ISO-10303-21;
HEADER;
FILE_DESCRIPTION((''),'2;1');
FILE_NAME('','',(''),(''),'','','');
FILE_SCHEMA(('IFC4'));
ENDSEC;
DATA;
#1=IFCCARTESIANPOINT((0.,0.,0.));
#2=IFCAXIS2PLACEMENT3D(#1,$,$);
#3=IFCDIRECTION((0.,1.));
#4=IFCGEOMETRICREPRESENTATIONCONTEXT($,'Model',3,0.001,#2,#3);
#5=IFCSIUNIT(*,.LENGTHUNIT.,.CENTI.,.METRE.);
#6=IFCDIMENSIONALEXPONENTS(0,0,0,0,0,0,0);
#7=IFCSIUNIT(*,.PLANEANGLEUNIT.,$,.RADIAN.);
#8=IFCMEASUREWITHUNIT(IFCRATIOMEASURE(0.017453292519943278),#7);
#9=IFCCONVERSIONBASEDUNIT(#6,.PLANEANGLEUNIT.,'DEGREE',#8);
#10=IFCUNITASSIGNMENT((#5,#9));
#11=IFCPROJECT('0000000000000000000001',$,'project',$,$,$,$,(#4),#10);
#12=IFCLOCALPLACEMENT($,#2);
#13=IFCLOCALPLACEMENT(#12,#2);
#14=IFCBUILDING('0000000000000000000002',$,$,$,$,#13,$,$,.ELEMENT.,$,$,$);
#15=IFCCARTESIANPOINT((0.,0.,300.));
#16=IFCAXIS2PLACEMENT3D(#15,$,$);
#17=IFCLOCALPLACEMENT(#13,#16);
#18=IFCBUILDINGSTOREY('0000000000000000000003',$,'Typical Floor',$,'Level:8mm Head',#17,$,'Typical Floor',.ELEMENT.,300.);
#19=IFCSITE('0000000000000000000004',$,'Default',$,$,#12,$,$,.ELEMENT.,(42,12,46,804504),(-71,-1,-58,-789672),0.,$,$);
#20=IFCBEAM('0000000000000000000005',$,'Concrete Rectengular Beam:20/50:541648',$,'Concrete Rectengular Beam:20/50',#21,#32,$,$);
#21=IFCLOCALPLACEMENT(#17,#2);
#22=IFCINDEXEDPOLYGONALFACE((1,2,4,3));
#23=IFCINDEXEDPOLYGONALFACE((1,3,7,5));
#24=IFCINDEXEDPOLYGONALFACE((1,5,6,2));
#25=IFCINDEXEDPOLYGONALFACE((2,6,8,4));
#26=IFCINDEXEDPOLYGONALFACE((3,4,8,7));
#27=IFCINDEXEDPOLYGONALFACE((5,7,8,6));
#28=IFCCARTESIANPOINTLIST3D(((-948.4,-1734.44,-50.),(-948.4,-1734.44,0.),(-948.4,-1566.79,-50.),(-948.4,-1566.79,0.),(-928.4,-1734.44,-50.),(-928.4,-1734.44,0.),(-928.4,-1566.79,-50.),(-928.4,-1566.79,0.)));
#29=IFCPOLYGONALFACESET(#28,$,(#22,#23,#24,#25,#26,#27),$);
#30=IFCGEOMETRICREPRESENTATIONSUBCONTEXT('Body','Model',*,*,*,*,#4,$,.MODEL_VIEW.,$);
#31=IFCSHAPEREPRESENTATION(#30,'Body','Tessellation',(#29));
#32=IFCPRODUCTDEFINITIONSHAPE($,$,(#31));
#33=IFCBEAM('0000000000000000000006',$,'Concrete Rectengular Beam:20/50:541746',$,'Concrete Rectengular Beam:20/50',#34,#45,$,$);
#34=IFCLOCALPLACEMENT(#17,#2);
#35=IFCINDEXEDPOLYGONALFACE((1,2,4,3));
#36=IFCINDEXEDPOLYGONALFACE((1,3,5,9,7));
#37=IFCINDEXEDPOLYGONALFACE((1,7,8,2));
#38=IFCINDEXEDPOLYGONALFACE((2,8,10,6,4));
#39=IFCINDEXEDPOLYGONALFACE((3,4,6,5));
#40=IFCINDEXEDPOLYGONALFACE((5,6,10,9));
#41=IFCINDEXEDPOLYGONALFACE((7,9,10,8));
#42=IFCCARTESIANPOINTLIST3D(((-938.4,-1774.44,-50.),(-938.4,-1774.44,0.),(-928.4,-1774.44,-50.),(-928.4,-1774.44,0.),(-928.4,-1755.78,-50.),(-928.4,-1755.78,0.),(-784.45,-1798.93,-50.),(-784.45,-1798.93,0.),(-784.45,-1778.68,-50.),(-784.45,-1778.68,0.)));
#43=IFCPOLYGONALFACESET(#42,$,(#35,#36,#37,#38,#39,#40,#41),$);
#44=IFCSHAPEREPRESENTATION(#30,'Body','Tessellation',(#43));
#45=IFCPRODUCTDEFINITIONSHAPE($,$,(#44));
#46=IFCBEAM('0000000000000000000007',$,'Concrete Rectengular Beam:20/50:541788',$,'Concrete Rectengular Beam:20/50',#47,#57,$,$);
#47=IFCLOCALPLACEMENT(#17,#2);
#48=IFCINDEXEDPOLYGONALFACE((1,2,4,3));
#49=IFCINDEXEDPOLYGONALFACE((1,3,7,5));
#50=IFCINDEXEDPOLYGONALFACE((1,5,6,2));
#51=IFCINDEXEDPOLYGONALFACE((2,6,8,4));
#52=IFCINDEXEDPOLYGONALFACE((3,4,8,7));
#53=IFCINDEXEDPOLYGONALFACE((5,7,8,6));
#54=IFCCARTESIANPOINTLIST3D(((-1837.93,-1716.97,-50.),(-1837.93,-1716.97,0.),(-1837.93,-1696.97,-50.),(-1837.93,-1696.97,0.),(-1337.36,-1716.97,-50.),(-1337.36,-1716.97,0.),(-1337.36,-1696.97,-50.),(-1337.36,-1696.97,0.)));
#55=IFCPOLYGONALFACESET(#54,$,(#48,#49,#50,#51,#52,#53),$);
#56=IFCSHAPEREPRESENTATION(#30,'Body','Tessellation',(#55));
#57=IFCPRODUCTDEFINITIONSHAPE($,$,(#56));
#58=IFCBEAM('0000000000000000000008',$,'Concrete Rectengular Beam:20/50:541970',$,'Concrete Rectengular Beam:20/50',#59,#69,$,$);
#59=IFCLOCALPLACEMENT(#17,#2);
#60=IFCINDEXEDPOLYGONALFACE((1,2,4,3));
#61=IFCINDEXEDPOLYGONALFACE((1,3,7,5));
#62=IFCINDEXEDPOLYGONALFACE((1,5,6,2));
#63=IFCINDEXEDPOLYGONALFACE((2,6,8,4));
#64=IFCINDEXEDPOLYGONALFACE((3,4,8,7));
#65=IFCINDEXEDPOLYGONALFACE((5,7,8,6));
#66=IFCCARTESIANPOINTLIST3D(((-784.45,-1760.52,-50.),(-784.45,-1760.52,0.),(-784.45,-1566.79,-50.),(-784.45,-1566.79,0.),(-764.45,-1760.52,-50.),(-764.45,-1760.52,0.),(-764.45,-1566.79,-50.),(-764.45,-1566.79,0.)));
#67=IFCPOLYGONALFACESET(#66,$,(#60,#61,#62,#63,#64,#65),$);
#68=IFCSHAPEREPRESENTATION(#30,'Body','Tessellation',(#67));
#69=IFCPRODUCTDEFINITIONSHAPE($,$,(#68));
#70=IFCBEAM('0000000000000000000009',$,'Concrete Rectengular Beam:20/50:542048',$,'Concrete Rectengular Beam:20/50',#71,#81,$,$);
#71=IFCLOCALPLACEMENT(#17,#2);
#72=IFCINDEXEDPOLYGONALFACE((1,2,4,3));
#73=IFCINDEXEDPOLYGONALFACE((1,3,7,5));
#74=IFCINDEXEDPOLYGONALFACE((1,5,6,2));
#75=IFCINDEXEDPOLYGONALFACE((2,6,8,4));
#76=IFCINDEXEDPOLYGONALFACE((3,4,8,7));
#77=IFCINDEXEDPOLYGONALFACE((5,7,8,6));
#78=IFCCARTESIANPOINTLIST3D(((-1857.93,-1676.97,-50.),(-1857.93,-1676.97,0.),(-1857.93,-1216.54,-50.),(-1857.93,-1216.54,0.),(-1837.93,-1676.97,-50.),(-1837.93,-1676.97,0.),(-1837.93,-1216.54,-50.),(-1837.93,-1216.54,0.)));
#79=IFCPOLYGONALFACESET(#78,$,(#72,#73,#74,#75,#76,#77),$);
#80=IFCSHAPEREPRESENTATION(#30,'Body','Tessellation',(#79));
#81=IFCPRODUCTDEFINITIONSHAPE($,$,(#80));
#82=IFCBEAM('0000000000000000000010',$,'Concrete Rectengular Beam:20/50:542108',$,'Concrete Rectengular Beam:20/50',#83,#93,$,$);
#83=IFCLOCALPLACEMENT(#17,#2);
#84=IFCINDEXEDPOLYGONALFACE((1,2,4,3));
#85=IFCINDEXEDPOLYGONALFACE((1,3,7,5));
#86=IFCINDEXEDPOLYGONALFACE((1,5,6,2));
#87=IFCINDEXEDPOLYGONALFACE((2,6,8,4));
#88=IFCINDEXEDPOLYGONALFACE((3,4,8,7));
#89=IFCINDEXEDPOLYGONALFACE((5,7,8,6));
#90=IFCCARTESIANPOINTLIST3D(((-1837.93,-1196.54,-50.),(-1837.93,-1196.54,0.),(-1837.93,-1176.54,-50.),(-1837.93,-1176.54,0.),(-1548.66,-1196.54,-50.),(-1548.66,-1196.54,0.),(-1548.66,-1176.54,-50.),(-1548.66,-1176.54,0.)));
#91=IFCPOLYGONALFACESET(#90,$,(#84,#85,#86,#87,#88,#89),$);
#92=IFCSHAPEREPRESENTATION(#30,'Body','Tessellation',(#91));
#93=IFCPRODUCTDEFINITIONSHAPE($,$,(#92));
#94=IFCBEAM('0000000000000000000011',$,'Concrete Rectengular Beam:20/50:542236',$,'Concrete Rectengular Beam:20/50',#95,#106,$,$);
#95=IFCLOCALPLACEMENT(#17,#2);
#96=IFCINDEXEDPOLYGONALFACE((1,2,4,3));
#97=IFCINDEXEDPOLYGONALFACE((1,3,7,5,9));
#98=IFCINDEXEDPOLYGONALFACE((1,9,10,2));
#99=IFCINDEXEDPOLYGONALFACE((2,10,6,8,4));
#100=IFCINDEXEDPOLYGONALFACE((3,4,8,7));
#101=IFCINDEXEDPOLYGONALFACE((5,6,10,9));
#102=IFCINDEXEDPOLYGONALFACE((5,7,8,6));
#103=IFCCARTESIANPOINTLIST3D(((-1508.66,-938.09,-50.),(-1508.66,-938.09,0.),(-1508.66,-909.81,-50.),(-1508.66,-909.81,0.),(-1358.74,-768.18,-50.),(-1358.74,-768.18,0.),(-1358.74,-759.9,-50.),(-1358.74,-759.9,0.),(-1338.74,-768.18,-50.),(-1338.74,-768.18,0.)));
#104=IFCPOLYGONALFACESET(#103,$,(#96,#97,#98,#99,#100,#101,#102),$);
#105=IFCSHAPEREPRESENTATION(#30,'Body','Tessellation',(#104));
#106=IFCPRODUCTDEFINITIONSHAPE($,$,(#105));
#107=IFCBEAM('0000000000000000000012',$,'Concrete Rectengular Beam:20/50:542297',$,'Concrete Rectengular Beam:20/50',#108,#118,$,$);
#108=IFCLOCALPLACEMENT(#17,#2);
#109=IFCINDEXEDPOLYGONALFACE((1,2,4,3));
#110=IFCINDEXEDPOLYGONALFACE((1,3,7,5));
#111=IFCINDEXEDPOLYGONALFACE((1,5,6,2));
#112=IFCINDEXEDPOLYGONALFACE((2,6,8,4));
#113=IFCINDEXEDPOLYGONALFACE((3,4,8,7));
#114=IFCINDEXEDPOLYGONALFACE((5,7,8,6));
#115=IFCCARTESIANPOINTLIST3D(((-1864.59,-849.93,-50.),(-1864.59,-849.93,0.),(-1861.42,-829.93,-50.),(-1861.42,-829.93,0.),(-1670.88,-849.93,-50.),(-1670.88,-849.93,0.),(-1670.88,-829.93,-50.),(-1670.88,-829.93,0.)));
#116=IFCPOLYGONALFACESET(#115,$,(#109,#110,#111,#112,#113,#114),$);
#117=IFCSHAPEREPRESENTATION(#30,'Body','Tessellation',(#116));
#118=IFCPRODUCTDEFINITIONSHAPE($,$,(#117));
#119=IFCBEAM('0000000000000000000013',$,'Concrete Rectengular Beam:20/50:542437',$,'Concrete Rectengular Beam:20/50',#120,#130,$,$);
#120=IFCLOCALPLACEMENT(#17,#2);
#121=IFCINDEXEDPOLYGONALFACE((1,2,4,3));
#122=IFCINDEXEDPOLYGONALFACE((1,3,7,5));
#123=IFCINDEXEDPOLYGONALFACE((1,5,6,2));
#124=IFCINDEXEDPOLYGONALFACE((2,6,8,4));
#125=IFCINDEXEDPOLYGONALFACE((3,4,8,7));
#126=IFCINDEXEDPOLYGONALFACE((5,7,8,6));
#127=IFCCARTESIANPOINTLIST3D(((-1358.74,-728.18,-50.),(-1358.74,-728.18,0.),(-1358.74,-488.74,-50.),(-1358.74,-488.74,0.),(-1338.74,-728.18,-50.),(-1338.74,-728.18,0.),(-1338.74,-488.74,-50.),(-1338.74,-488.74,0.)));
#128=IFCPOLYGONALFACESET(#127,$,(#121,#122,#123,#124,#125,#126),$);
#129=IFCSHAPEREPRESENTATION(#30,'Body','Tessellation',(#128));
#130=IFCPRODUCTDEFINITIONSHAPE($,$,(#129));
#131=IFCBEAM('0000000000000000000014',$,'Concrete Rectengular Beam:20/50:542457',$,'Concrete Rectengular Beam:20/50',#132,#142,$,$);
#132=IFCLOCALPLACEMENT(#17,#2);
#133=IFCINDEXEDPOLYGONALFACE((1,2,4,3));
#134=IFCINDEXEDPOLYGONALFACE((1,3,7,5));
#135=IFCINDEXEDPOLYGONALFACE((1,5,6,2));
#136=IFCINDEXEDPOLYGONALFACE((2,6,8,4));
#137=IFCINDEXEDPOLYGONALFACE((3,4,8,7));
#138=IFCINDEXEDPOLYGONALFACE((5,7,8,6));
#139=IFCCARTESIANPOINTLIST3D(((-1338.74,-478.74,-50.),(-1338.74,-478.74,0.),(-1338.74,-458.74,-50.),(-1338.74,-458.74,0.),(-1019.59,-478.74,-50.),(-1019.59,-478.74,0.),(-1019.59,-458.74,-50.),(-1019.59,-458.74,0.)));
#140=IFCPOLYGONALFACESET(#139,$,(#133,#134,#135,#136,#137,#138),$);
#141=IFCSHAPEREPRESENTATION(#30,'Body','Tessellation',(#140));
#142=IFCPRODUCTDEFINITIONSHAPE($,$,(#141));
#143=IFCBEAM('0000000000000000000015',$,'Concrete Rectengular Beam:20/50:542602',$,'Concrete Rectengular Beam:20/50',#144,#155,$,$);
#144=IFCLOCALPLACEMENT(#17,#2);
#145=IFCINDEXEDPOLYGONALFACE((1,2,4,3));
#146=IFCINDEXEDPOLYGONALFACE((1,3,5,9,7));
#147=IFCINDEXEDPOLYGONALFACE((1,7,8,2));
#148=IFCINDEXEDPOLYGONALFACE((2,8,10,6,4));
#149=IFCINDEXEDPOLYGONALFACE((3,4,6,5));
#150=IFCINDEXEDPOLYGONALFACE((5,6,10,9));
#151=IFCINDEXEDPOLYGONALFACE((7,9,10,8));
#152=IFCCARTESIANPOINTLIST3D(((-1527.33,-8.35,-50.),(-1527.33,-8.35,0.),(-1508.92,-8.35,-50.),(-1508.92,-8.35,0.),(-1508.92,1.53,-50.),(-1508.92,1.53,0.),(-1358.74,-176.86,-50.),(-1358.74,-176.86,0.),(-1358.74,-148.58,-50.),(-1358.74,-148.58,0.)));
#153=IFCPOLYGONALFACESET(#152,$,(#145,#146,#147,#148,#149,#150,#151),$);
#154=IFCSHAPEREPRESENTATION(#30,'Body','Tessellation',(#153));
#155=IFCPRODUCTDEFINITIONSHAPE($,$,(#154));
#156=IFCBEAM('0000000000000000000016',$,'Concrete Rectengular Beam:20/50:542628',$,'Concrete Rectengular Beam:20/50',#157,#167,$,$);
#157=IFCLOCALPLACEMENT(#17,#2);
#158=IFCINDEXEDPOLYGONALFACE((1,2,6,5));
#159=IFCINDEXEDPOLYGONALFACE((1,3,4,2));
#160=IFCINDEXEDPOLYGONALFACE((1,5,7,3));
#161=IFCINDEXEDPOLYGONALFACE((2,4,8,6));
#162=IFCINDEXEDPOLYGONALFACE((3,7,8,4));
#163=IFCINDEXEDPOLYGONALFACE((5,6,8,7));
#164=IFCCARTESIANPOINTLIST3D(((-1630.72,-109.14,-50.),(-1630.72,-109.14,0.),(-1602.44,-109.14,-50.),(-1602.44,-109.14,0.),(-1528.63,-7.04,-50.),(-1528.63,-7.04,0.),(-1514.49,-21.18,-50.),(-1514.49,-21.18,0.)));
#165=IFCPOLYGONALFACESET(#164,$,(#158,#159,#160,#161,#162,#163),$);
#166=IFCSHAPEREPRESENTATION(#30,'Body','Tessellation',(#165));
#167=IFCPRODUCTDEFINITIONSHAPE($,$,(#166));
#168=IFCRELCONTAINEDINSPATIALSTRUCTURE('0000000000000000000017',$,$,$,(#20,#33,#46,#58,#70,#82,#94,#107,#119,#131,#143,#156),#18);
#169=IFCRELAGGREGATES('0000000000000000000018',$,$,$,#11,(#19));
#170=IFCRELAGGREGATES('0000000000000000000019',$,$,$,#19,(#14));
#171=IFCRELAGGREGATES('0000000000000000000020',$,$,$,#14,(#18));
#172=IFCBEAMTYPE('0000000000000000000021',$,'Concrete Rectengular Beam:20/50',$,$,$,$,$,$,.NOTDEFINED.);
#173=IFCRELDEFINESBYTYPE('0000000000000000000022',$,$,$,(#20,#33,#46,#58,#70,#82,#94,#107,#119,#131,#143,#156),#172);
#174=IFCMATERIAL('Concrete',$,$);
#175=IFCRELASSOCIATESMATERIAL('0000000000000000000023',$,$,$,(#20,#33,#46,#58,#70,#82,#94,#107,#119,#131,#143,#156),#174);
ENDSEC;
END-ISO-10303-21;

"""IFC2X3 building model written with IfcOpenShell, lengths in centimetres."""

from ifc_helpers import new_model, entity, si_unit, converted_unit, direction, frame, frame_2d, origin, place, context, subcontext, project, spatial, polyline, rectangle, extrude, clip, halfspace, bounded_halfspace, material, type_object, element, save


model = new_model("IFC2X3")

# Units and contexts
model_context = context("Model", 3, precision=0.001, world=origin(), true_north=direction((0.0, 1.0)))
body_context = subcontext(model_context, "Body", "Model", "MODEL_VIEW")
ifc_project = project(units=[si_unit("LENGTHUNIT", "METRE", prefix="CENTI"), converted_unit("PLANEANGLEUNIT", "DEGREE", entity("IfcRatioMeasure", 0.017453292519943278), si_unit("PLANEANGLEUNIT", "RADIAN"), dimensions=[0, 0, 0, 0, 0, 0, 0])], contexts=[model_context])

# Site, building, storey
site_placement = place(None, origin())
site = spatial("IfcSite", under=ifc_project, at=site_placement, Name="Default", CompositionType="ELEMENT", RefLatitude=(42, 12, 46, 804504), RefLongitude=(-71, -1, -58, -789672), RefElevation=0.0)
building_placement = place(site_placement, origin())
building = spatial("IfcBuilding", under=site, at=building_placement, CompositionType="ELEMENT")
storey_placement = place(building_placement, frame((0.0, 0.0, 300.0)))
storey = spatial("IfcBuildingStorey", under=building, at=storey_placement, Name="Typical Floor", ObjectType="Level:8mm Head", LongName="Typical Floor", CompositionType="ELEMENT", Elevation=300.0)

# Beams
ifc_material = material(Name="Concrete")
beam_type_1 = type_object("IfcBeamType", Name="Concrete Rectengular Beam:20/50", PredefinedType="NOTDEFINED")
beam_1_placement = place(storey_placement, frame((-938.4, -1754.44, 0.0), z_axis=(0.0, 0.0, 1.0), x_axis=(0.0, 1.0, 0.0)))
element("IfcBeam", 1, at=beam_1_placement, inside=storey, type_object=beam_type_1, material=ifc_material, Name="Concrete Rectengular Beam:20/50:541648", ObjectType="Concrete Rectengular Beam:20/50", context=body_context, shape_type="SweptSolid", body=[
    extrude(rectangle(XDim=50.0, YDim=20.0, at=frame_2d((0.0, 0.0), x_axis=(1.0, 0.0))), frame((20.0, 0.0, -25.0), z_axis=(1.0, 0.0, 0.0), x_axis=(0.0, 0.0, -1.0)), (0.0, 0.0, 1.0), 167.65),
])
beam_2_placement = place(storey_placement, frame((-774.45, -1800.52, 0.0), z_axis=(0.0, 0.0, 1.0), x_axis=(-0.98758, 0.157115, 0.0)))
element("IfcBeam", 2, at=beam_2_placement, inside=storey, type_object=beam_type_1, material=ifc_material, Name="Concrete Rectengular Beam:20/50:541746", ObjectType="Concrete Rectengular Beam:20/50", context=body_context, shape_type="SweptSolid", body=[
    clip(clip(clip(extrude(rectangle(XDim=50.0, YDim=20.0, at=frame_2d((0.0, 0.0), x_axis=(1.0, 0.0))), frame((10.13, -10.0, -25.0), z_axis=(1.0, 0.0, 0.0), x_axis=(0.0, 0.0, -1.0)), (0.0, 0.0, 1.0), 155.89), halfspace(frame((16.16, -37.93, 0.0), z_axis=(-0.98758, -0.157115, 0.0), x_axis=(0.0, 0.0, -1.0)), False)), bounded_halfspace(frame((156.14, -1.57, 0.0), z_axis=(0.98758, 0.157115, 0.0), x_axis=(0.0, 0.0, -1.0)), False, frame((10.13, -10.0, -25.0), z_axis=(1.0, 0.0, 0.0), x_axis=(0.0, 0.0, -1.0)), polyline([(25.0, 8.43), (-25.0, 8.43), (-25.0, -10.0), (-5.0, -10.0), (25.0, -10.0), (25.0, 8.43)]))), bounded_halfspace(frame((175.89, 1.57, 0.0), z_axis=(0.157115, -0.98758, 0.0), x_axis=(0.0, 0.0, -1.0)), False, frame((10.13, -10.0, -25.0), z_axis=(1.0, 0.0, 0.0), x_axis=(0.0, 0.0, -1.0)), polyline([(-25.0, 8.43), (25.0, 8.43), (25.0, 10.0), (-25.0, 10.0), (-25.0, 8.43)]))),
])
beam_3_placement = place(storey_placement, frame((-1317.36, -1716.97, 0.0), z_axis=(0.0, 0.0, 1.0), x_axis=(-1.0, 0.0, 0.0)))
element("IfcBeam", 3, at=beam_3_placement, inside=storey, type_object=beam_type_1, material=ifc_material, Name="Concrete Rectengular Beam:20/50:541788", ObjectType="Concrete Rectengular Beam:20/50", context=body_context, shape_type="SweptSolid", body=[
    extrude(rectangle(XDim=50.0, YDim=20.0, at=frame_2d((0.0, 0.0), x_axis=(1.0, 0.0))), frame((20.0, -10.0, -25.0), z_axis=(1.0, 0.0, 0.0), x_axis=(0.0, 0.0, -1.0)), (0.0, 0.0, 1.0), 500.57),
])
beam_4_placement = place(storey_placement, frame((-784.45, -1780.52, 0.0), z_axis=(0.0, 0.0, 1.0), x_axis=(0.0, 1.0, 0.0)))
element("IfcBeam", 4, at=beam_4_placement, inside=storey, type_object=beam_type_1, material=ifc_material, Name="Concrete Rectengular Beam:20/50:541970", ObjectType="Concrete Rectengular Beam:20/50", context=body_context, shape_type="SweptSolid", body=[
    extrude(rectangle(XDim=50.0, YDim=20.0, at=frame_2d((0.0, 0.0), x_axis=(1.0, 0.0))), frame((20.0, -10.0, -25.0), z_axis=(1.0, 0.0, 0.0), x_axis=(0.0, 0.0, -1.0)), (0.0, 0.0, 1.0), 193.73),
])
beam_5_placement = place(storey_placement, frame((-1857.93, -1697.16, 0.0), z_axis=(0.0, 0.0, 1.0), x_axis=(0.0, 1.0, 0.0)))
element("IfcBeam", 5, at=beam_5_placement, inside=storey, type_object=beam_type_1, material=ifc_material, Name="Concrete Rectengular Beam:20/50:542048", ObjectType="Concrete Rectengular Beam:20/50", context=body_context, shape_type="SweptSolid", body=[
    extrude(rectangle(XDim=50.0, YDim=20.0, at=frame_2d((0.0, 0.0), x_axis=(1.0, 0.0))), frame((20.19, -10.0, -25.0), z_axis=(1.0, 0.0, 0.0), x_axis=(0.0, 0.0, -1.0)), (0.0, 0.0, 1.0), 460.44),
])
beam_6_placement = place(storey_placement, frame((-1847.93, -1176.54, 0.0)))
element("IfcBeam", 6, at=beam_6_placement, inside=storey, type_object=beam_type_1, material=ifc_material, Name="Concrete Rectengular Beam:20/50:542108", ObjectType="Concrete Rectengular Beam:20/50", context=body_context, shape_type="SweptSolid", body=[
    extrude(rectangle(XDim=50.0, YDim=20.0, at=frame_2d((0.0, 0.0), x_axis=(1.0, 0.0))), frame((10.0, -10.0, -25.0), z_axis=(1.0, 0.0, 0.0), x_axis=(0.0, 0.0, -1.0)), (0.0, 0.0, 1.0), 289.28),
])
beam_7_placement = place(storey_placement, frame((-1515.66, -930.95, 0.0), z_axis=(0.0, 0.0, 1.0), x_axis=(0.707107, 0.707107, 0.0)))
element("IfcBeam", 7, at=beam_7_placement, inside=storey, type_object=beam_type_1, material=ifc_material, Name="Concrete Rectengular Beam:20/50:542236", ObjectType="Concrete Rectengular Beam:20/50", context=body_context, shape_type="SweptSolid", body=[
    clip(clip(clip(extrude(rectangle(XDim=50.0, YDim=20.0, at=frame_2d((0.0, 0.0), x_axis=(1.0, 0.0))), frame((-0.1, 0.0, -25.0), z_axis=(1.0, 0.0, 0.0), x_axis=(0.0, 0.0, -1.0)), (0.0, 0.0, 1.0), 240.29), halfspace(frame((-167.8, -177.7, -50.0), z_axis=(-0.707107, 0.707107, 0.0), x_axis=(0.707107, 0.707107, 0.0)), False)), bounded_halfspace(frame((226.05, 4.14, 0.0), z_axis=(0.707107, 0.707107, 0.0), x_axis=(0.0, 0.0, -1.0)), False, frame((-0.1, 0.0, -25.0), z_axis=(1.0, 0.0, 0.0), x_axis=(0.0, 0.0, -1.0)), polyline([(25.0, 4.14), (-25.0, 4.14), (-25.0, -10.0), (-5.0, -10.0), (25.0, -10.0), (25.0, 4.14)]))), bounded_halfspace(frame((254.34, 32.43, 0.0), z_axis=(0.707107, -0.707107, 0.0), x_axis=(0.0, 0.0, -1.0)), False, frame((-0.1, 0.0, -25.0), z_axis=(1.0, 0.0, 0.0), x_axis=(0.0, 0.0, -1.0)), polyline([(-25.0, 4.14), (25.0, 4.14), (25.0, 10.0), (-25.0, 10.0), (-25.0, 4.14)]))),
])
beam_8_placement = place(storey_placement, frame((-1660.88, -839.93, 0.0), z_axis=(0.0, 0.0, 1.0), x_axis=(-1.0, 0.0, 0.0)))
element("IfcBeam", 8, at=beam_8_placement, inside=storey, type_object=beam_type_1, material=ifc_material, Name="Concrete Rectengular Beam:20/50:542297", ObjectType="Concrete Rectengular Beam:20/50", context=body_context, shape_type="SweptSolid", body=[
    clip(extrude(rectangle(XDim=50.0, YDim=20.0, at=frame_2d((0.0, 0.0), x_axis=(1.0, 0.0))), frame((10.0, 0.0, -25.0), z_axis=(1.0, 0.0, 0.0), x_axis=(0.0, 0.0, -1.0)), (0.0, 0.0, 1.0), 193.71), halfspace(frame((199.87, -14.26, -50.0), z_axis=(0.987688, -0.156434, 0.0), x_axis=(0.156434, 0.987688, 0.0)), False)),
])
beam_9_placement = place(storey_placement, frame((-1348.74, -748.18, 0.0), z_axis=(0.0, 0.0, 1.0), x_axis=(0.0, 1.0, 0.0)))
element("IfcBeam", 9, at=beam_9_placement, inside=storey, type_object=beam_type_1, material=ifc_material, Name="Concrete Rectengular Beam:20/50:542437", ObjectType="Concrete Rectengular Beam:20/50", context=body_context, shape_type="SweptSolid", body=[
    extrude(rectangle(XDim=50.0, YDim=20.0, at=frame_2d((0.0, 0.0), x_axis=(1.0, 0.0))), frame((20.0, 0.0, -25.0), z_axis=(1.0, 0.0, 0.0), x_axis=(0.0, 0.0, -1.0)), (0.0, 0.0, 1.0), 239.44),
])
beam_10_placement = place(storey_placement, frame((-1348.74, -468.74, 0.0)))
element("IfcBeam", 10, at=beam_10_placement, inside=storey, type_object=beam_type_1, material=ifc_material, Name="Concrete Rectengular Beam:20/50:542457", ObjectType="Concrete Rectengular Beam:20/50", context=body_context, shape_type="SweptSolid", body=[
    extrude(rectangle(XDim=50.0, YDim=20.0, at=frame_2d((0.0, 0.0), x_axis=(1.0, 0.0))), frame((10.0, 0.0, -25.0), z_axis=(1.0, 0.0, 0.0), x_axis=(0.0, 0.0, -1.0)), (0.0, 0.0, 1.0), 319.15),
])
beam_11_placement = place(storey_placement, frame((-1350.67, -170.79, 0.0), z_axis=(0.0, 0.0, 1.0), x_axis=(-0.707263, 0.70695, 0.0)))
element("IfcBeam", 11, at=beam_11_placement, inside=storey, type_object=beam_type_1, material=ifc_material, Name="Concrete Rectengular Beam:20/50:542602", ObjectType="Concrete Rectengular Beam:20/50", context=body_context, shape_type="SweptSolid", body=[
    clip(clip(clip(extrude(rectangle(XDim=50.0, YDim=20.0, at=frame_2d((0.0, 0.0), x_axis=(1.0, 0.0))), frame((1.41, 0.0, -25.0), z_axis=(1.0, 0.0, 0.0), x_axis=(0.0, 0.0, -1.0)), (0.0, 0.0, 1.0), 238.36), halfspace(frame((-22.11, 33.53, -25.0), z_axis=(-0.707263, -0.70695, 0.0), x_axis=(0.0, 0.0, 1.0)), False)), bounded_halfspace(frame((226.75, -3.01, 0.0), z_axis=(0.707263, 0.70695, 0.0), x_axis=(0.0, 0.0, -1.0)), False, frame((1.41, 0.0, -25.0), z_axis=(1.0, 0.0, 0.0), x_axis=(0.0, 0.0, -1.0)), polyline([(25.0, -3.01), (-25.0, -3.01), (-25.0, -10.0), (25.0, -10.0), (25.0, -3.01)]))), bounded_halfspace(frame((240.9, 11.13, 0.0), z_axis=(0.70695, -0.707263, 0.0), x_axis=(0.0, 0.0, -1.0)), False, frame((1.41, 0.0, -25.0), z_axis=(1.0, 0.0, 0.0), x_axis=(0.0, 0.0, -1.0)), polyline([(-25.0, -3.01), (25.0, -3.01), (25.0, 10.0), (-25.0, 10.0), (-25.0, -3.01)]))),
])
beam_12_placement = place(storey_placement, frame((-1514.49, -7.04, 0.0), z_axis=(0.0, 0.0, 1.0), x_axis=(-0.707107, -0.707107, 0.0)))
element("IfcBeam", 12, at=beam_12_placement, inside=storey, type_object=beam_type_1, material=ifc_material, Name="Concrete Rectengular Beam:20/50:542628", ObjectType="Concrete Rectengular Beam:20/50", context=body_context, shape_type="SweptSolid", body=[
    clip(extrude(rectangle(XDim=50.0, YDim=20.0, at=frame_2d((0.0, 0.0), x_axis=(1.0, 0.0))), frame((10.0, 0.0, -25.0), z_axis=(1.0, 0.0, 0.0), x_axis=(0.0, 0.0, -1.0)), (0.0, 0.0, 1.0), 144.38), halfspace(frame((118.72, 25.66, 0.0), z_axis=(0.707107, 0.707107, 0.0), x_axis=(0.707107, -0.707107, 0.0)), False)),
])

save(model, "model.ifc")
